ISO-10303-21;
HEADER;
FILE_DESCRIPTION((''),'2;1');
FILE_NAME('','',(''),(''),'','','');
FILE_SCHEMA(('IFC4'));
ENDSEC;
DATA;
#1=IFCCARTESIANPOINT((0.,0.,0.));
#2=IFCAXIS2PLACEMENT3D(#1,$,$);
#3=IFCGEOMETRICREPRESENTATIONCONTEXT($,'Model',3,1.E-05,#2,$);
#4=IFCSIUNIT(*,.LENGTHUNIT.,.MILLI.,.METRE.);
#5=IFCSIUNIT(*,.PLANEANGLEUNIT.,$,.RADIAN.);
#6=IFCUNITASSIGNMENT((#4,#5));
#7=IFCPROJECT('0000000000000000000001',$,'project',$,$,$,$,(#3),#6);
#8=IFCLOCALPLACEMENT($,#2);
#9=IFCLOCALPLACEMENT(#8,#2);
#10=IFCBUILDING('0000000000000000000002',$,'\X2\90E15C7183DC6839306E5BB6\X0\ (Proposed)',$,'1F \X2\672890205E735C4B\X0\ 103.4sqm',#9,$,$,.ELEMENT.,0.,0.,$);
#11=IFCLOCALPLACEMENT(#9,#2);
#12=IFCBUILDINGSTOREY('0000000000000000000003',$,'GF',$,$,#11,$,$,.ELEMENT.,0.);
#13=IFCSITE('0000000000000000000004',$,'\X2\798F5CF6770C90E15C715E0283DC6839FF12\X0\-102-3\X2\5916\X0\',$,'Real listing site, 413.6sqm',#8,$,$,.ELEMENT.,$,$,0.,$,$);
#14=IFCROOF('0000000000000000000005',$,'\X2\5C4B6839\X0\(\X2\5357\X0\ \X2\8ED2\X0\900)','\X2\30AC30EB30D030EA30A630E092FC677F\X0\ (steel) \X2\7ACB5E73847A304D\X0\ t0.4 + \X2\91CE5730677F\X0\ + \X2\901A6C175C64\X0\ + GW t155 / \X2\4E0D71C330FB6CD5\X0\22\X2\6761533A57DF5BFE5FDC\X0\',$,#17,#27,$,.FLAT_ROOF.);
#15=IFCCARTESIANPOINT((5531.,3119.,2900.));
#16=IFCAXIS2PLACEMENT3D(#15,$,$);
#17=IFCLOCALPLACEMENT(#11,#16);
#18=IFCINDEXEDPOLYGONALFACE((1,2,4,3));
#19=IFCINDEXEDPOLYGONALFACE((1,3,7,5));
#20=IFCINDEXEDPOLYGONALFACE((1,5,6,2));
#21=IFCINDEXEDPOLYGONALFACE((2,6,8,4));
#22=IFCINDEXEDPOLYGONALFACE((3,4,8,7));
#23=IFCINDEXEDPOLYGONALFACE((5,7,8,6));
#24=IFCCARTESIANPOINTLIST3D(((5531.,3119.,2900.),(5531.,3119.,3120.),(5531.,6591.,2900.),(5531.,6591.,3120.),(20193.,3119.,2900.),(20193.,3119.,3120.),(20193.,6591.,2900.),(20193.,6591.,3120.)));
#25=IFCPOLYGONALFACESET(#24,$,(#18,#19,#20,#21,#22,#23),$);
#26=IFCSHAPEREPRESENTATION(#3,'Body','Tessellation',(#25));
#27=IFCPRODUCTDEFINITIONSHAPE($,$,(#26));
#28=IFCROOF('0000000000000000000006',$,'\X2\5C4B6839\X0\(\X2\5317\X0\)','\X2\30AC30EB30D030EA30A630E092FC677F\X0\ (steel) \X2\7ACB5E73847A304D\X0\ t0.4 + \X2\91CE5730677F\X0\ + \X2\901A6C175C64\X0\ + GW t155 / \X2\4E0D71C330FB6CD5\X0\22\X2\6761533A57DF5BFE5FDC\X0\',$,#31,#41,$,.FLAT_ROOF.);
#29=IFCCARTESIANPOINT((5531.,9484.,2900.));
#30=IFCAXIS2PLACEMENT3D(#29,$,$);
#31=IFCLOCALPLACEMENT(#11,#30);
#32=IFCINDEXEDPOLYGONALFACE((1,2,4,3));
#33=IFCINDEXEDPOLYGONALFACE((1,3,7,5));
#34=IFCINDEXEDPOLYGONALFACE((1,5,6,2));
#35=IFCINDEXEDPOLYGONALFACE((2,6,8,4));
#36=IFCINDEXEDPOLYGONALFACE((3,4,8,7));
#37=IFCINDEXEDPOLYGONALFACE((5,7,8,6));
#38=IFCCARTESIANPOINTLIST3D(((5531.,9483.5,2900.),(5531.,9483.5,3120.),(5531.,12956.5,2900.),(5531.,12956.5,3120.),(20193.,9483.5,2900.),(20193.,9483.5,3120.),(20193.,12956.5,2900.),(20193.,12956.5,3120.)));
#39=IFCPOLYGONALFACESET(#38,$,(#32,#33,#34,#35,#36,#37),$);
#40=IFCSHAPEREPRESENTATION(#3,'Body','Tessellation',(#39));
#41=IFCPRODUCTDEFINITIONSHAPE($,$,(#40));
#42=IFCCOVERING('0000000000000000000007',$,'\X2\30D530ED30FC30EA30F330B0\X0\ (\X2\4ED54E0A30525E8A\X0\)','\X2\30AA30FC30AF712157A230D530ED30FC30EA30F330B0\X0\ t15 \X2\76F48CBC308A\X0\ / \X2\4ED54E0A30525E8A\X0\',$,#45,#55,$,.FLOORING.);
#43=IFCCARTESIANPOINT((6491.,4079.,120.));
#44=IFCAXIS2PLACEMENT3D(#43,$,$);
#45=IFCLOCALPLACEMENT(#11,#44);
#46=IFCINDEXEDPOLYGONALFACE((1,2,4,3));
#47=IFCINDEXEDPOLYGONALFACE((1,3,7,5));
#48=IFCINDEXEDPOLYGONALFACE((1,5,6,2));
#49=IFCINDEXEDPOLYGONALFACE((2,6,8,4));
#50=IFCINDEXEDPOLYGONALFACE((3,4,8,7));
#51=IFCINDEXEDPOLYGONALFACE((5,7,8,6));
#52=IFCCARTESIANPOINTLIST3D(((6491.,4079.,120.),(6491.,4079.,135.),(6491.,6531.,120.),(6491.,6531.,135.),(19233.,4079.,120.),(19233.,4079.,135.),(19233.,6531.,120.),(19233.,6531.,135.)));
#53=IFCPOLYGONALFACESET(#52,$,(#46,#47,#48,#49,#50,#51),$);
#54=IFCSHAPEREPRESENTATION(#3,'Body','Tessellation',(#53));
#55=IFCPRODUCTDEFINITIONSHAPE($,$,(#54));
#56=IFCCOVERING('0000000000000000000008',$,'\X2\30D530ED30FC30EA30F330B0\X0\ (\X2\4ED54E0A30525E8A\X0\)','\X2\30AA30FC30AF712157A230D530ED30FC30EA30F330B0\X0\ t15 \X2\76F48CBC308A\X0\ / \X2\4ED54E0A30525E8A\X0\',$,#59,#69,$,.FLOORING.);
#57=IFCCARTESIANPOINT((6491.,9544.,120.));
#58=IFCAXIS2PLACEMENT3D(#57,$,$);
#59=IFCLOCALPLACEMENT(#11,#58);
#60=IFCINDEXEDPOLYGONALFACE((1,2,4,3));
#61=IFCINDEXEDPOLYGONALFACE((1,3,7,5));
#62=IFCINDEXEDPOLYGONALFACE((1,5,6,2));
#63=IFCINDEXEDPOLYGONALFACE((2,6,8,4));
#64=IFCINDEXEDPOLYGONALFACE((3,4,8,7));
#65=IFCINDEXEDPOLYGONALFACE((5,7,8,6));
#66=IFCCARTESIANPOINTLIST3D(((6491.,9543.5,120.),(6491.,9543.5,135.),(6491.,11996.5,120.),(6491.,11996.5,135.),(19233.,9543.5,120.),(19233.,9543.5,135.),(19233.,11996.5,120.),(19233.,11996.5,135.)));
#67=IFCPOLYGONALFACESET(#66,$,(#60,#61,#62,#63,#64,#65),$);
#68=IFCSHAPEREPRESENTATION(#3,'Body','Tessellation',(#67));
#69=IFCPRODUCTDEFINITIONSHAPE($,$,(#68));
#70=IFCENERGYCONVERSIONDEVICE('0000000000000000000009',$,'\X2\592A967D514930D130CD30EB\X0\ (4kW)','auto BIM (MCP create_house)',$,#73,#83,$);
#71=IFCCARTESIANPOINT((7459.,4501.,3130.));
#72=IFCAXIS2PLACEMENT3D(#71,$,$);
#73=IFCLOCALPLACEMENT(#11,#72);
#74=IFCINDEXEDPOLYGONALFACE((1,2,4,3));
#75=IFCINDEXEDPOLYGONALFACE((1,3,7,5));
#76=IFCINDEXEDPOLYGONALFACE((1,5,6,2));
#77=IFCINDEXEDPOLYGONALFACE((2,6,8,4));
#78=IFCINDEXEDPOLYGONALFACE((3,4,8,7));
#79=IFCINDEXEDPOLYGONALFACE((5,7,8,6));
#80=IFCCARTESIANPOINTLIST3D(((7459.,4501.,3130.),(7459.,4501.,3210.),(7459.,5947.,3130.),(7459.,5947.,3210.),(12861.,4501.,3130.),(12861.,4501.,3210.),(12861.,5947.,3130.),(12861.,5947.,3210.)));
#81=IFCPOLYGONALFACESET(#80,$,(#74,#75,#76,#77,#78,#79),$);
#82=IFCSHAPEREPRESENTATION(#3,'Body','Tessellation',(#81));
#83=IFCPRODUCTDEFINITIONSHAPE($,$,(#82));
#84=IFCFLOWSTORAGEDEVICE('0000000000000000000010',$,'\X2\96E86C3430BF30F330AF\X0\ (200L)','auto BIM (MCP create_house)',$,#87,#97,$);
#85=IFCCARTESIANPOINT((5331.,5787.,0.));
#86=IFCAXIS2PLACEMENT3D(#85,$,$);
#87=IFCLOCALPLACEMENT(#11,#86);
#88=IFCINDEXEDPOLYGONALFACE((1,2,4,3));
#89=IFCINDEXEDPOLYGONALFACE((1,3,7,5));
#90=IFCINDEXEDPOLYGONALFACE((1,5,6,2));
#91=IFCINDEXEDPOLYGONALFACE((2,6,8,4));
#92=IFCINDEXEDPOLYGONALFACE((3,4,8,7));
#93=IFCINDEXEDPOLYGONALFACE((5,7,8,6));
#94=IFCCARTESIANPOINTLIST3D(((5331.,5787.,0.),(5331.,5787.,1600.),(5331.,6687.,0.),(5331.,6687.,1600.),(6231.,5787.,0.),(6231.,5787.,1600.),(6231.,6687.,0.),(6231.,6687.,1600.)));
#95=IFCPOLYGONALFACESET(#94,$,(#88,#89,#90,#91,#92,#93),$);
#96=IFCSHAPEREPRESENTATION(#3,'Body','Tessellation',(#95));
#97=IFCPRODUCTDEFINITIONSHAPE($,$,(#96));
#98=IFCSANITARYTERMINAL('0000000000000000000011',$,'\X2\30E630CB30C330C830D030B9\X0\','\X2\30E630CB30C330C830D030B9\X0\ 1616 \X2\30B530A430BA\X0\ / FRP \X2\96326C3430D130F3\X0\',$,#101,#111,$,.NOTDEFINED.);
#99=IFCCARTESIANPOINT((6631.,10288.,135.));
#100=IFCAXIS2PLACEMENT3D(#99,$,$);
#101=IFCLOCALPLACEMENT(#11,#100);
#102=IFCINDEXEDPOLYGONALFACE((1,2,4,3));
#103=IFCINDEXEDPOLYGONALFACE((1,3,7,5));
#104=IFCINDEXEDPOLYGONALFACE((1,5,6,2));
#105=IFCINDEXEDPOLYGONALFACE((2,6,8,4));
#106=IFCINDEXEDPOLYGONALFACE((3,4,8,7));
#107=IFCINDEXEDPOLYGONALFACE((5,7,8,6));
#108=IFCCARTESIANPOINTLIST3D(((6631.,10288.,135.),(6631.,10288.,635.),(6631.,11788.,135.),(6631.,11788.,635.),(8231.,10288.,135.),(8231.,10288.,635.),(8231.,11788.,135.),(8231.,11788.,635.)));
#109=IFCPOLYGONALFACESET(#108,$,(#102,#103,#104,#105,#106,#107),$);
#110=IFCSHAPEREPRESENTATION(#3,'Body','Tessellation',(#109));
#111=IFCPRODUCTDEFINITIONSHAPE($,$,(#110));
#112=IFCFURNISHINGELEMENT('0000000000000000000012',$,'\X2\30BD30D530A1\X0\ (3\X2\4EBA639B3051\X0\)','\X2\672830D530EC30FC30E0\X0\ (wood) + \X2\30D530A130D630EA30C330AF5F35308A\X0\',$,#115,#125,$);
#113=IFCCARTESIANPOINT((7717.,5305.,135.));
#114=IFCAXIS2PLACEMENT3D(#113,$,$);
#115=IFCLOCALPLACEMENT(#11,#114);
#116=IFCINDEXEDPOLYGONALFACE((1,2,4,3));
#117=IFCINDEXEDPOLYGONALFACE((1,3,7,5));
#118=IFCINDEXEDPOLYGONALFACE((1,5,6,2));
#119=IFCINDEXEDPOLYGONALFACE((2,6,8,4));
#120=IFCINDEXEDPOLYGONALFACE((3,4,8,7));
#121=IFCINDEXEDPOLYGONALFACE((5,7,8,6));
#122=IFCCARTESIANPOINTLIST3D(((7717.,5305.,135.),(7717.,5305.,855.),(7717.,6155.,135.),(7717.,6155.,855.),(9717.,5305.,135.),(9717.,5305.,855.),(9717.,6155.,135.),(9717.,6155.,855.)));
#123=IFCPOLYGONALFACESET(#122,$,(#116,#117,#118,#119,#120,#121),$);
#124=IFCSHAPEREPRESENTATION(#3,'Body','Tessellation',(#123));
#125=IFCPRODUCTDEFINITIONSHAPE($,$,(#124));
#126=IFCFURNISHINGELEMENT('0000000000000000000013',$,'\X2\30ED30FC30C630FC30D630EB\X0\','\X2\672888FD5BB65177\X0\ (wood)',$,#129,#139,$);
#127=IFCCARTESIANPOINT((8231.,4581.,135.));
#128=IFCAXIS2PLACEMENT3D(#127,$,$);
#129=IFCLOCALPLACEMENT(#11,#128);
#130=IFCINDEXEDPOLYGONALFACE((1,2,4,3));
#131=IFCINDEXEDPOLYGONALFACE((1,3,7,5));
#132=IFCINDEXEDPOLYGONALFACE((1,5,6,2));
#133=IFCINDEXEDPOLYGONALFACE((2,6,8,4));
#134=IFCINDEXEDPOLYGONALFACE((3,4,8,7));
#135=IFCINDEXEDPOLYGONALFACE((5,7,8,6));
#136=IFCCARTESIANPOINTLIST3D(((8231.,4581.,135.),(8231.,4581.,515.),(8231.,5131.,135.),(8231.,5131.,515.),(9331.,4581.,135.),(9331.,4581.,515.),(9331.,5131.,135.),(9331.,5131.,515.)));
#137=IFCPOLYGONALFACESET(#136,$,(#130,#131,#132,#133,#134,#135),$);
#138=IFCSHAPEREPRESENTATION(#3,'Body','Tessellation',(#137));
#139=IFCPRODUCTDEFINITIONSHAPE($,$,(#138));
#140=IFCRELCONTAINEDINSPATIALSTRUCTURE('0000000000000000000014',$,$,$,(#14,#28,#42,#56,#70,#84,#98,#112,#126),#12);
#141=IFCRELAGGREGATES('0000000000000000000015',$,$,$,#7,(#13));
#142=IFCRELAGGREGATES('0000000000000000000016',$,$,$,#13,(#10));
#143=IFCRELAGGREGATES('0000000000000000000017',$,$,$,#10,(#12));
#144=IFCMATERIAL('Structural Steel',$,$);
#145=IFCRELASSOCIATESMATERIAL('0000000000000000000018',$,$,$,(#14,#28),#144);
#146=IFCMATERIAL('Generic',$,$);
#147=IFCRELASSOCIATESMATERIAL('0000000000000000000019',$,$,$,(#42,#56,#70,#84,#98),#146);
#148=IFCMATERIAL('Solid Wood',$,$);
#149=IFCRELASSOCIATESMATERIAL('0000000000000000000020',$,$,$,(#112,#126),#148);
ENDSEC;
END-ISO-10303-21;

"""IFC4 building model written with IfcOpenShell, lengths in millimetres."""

from ifc_helpers import new_model, si_unit, frame, frame_2d, origin, place, context, project, spatial, rectangle, extrude, material, element, save


model = new_model("IFC4")

# Units and contexts
model_context = context("Model", 3, precision=1e-05, world=origin())
ifc_project = project(units=[si_unit("LENGTHUNIT", "METRE", prefix="MILLI"), si_unit("PLANEANGLEUNIT", "RADIAN")], contexts=[model_context])

# Site, building, storey
site_placement = place(None, origin())
site = spatial("IfcSite", under=ifc_project, at=site_placement, Name="福島県郡山市菜根２-102-3外", ObjectType="Real listing site, 413.6sqm", CompositionType="ELEMENT", RefElevation=0.0)
building_placement = place(site_placement, origin())
building = spatial("IfcBuilding", under=site, at=building_placement, Name="郡山菜根の家 (Proposed)", ObjectType="1F 木造平屋 103.4sqm", CompositionType="ELEMENT", ElevationOfRefHeight=0.0, ElevationOfTerrain=0.0)
storey_placement = place(building_placement, origin())
storey = spatial("IfcBuildingStorey", under=building, at=storey_placement, Name="GF", CompositionType="ELEMENT", Elevation=0.0)

# Shared definitions
ifc_material_1 = material(Name="Solid Wood")

# Roofs
ifc_material_2 = material(Name="Structural Steel")
roof_1_placement = place(storey_placement, frame((5531.0, 3119.0, 2900.0)))
element("IfcRoof", 1, at=roof_1_placement, inside=storey, material=ifc_material_2, Name="屋根(南 軒900)", Description="ガルバリウム鋼板 (steel) 立平葺き t0.4 + 野地板 + 通気層 + GW t155 / 不燃・法22条区域対応", PredefinedType="FLAT_ROOF", context=model_context, shape_type="SweptSolid", body=[
    extrude(rectangle(XDim=14662.0, YDim=3472.0, at=frame_2d((7331.0, 1736.0))), frame((5531.0, 3119.0, 2900.0)), (0.0, 0.0, 1.0), 220.0),
])
roof_2_placement = place(storey_placement, frame((5531.0, 9484.0, 2900.0)))
element("IfcRoof", 2, at=roof_2_placement, inside=storey, material=ifc_material_2, Name="屋根(北)", Description="ガルバリウム鋼板 (steel) 立平葺き t0.4 + 野地板 + 通気層 + GW t155 / 不燃・法22条区域対応", PredefinedType="FLAT_ROOF", context=model_context, shape_type="SweptSolid", body=[
    extrude(rectangle(XDim=14662.0, YDim=3473.0, at=frame_2d((7331.0, 1736.0))), frame((5531.0, 9484.0, 2900.0)), (0.0, 0.0, 1.0), 220.0),
])

# Coverings
ifc_material_3 = material(Name="Generic")
covering_1_placement = place(storey_placement, frame((6491.0, 4079.0, 120.0)))
element("IfcCovering", 3, at=covering_1_placement, inside=storey, material=ifc_material_3, Name="フローリング (仕上げ床)", Description="オーク無垢フローリング t15 直貼り / 仕上げ床", PredefinedType="FLOORING", context=model_context, shape_type="SweptSolid", body=[
    extrude(rectangle(XDim=12742.0, YDim=2452.0, at=frame_2d((6371.0, 1226.0))), frame((6491.0, 4079.0, 120.0)), (0.0, 0.0, 1.0), 15.0),
])
covering_2_placement = place(storey_placement, frame((6491.0, 9544.0, 120.0)))
element("IfcCovering", 4, at=covering_2_placement, inside=storey, material=ifc_material_3, Name="フローリング (仕上げ床)", Description="オーク無垢フローリング t15 直貼り / 仕上げ床", PredefinedType="FLOORING", context=model_context, shape_type="SweptSolid", body=[
    extrude(rectangle(XDim=12742.0, YDim=2453.0, at=frame_2d((6371.0, 1226.0))), frame((6491.0, 9544.0, 120.0)), (0.0, 0.0, 1.0), 15.0),
])

# Energy conversion device
energy_conversion_device_placement = place(storey_placement, frame((7459.0, 4501.0, 3130.0)))
element("IfcEnergyConversionDevice", 5, at=energy_conversion_device_placement, inside=storey, material=ifc_material_3, Name="太陽光パネル (4kW)", Description="auto BIM (MCP create_house)", context=model_context, shape_type="SweptSolid", body=[
    extrude(rectangle(XDim=5402.0, YDim=1446.0, at=frame_2d((2701.0, 723.0))), frame((7459.0, 4501.0, 3130.0)), (0.0, 0.0, 1.0), 80.0),
])

# Flow storage device
flow_storage_device_placement = place(storey_placement, frame((5331.0, 5787.0, 0.0)))
element("IfcFlowStorageDevice", 6, at=flow_storage_device_placement, inside=storey, material=ifc_material_3, Name="雨水タンク (200L)", Description="auto BIM (MCP create_house)", context=model_context, shape_type="SweptSolid", body=[
    extrude(rectangle(XDim=900.0, YDim=900.0, at=frame_2d((450.0, 450.0))), frame((5331.0, 5787.0, 0.0)), (0.0, 0.0, 1.0), 1600.0),
])

# Sanitary terminal
sanitary_terminal_placement = place(storey_placement, frame((6631.0, 10288.0, 135.0)))
element("IfcSanitaryTerminal", 7, at=sanitary_terminal_placement, inside=storey, material=ifc_material_3, Name="ユニットバス", Description="ユニットバス 1616 サイズ / FRP 防水パン", PredefinedType="NOTDEFINED", context=model_context, shape_type="SweptSolid", body=[
    extrude(rectangle(XDim=1600.0, YDim=1500.0, at=frame_2d((800.0, 750.0))), frame((6631.0, 10288.0, 135.0)), (0.0, 0.0, 1.0), 500.0),
])

# Furnishing elements
furnishing_1_placement = place(storey_placement, frame((7717.0, 5305.0, 135.0)))
element("IfcFurnishingElement", 8, at=furnishing_1_placement, inside=storey, material=ifc_material_1, Name="ソファ (3人掛け)", Description="木フレーム (wood) + ファブリック張り", context=model_context, shape_type="SweptSolid", body=[
    extrude(rectangle(XDim=2000.0, YDim=850.0, at=frame_2d((1000.0, 425.0))), frame((7717.0, 5305.0, 135.0)), (0.0, 0.0, 1.0), 720.0),
])
furnishing_2_placement = place(storey_placement, frame((8231.0, 4581.0, 135.0)))
element("IfcFurnishingElement", 9, at=furnishing_2_placement, inside=storey, material=ifc_material_1, Name="ローテーブル", Description="木製家具 (wood)", context=model_context, shape_type="SweptSolid", body=[
    extrude(rectangle(XDim=1100.0, YDim=550.0, at=frame_2d((550.0, 275.0))), frame((8231.0, 4581.0, 135.0)), (0.0, 0.0, 1.0), 380.0),
])

save(model, "model.ifc")
